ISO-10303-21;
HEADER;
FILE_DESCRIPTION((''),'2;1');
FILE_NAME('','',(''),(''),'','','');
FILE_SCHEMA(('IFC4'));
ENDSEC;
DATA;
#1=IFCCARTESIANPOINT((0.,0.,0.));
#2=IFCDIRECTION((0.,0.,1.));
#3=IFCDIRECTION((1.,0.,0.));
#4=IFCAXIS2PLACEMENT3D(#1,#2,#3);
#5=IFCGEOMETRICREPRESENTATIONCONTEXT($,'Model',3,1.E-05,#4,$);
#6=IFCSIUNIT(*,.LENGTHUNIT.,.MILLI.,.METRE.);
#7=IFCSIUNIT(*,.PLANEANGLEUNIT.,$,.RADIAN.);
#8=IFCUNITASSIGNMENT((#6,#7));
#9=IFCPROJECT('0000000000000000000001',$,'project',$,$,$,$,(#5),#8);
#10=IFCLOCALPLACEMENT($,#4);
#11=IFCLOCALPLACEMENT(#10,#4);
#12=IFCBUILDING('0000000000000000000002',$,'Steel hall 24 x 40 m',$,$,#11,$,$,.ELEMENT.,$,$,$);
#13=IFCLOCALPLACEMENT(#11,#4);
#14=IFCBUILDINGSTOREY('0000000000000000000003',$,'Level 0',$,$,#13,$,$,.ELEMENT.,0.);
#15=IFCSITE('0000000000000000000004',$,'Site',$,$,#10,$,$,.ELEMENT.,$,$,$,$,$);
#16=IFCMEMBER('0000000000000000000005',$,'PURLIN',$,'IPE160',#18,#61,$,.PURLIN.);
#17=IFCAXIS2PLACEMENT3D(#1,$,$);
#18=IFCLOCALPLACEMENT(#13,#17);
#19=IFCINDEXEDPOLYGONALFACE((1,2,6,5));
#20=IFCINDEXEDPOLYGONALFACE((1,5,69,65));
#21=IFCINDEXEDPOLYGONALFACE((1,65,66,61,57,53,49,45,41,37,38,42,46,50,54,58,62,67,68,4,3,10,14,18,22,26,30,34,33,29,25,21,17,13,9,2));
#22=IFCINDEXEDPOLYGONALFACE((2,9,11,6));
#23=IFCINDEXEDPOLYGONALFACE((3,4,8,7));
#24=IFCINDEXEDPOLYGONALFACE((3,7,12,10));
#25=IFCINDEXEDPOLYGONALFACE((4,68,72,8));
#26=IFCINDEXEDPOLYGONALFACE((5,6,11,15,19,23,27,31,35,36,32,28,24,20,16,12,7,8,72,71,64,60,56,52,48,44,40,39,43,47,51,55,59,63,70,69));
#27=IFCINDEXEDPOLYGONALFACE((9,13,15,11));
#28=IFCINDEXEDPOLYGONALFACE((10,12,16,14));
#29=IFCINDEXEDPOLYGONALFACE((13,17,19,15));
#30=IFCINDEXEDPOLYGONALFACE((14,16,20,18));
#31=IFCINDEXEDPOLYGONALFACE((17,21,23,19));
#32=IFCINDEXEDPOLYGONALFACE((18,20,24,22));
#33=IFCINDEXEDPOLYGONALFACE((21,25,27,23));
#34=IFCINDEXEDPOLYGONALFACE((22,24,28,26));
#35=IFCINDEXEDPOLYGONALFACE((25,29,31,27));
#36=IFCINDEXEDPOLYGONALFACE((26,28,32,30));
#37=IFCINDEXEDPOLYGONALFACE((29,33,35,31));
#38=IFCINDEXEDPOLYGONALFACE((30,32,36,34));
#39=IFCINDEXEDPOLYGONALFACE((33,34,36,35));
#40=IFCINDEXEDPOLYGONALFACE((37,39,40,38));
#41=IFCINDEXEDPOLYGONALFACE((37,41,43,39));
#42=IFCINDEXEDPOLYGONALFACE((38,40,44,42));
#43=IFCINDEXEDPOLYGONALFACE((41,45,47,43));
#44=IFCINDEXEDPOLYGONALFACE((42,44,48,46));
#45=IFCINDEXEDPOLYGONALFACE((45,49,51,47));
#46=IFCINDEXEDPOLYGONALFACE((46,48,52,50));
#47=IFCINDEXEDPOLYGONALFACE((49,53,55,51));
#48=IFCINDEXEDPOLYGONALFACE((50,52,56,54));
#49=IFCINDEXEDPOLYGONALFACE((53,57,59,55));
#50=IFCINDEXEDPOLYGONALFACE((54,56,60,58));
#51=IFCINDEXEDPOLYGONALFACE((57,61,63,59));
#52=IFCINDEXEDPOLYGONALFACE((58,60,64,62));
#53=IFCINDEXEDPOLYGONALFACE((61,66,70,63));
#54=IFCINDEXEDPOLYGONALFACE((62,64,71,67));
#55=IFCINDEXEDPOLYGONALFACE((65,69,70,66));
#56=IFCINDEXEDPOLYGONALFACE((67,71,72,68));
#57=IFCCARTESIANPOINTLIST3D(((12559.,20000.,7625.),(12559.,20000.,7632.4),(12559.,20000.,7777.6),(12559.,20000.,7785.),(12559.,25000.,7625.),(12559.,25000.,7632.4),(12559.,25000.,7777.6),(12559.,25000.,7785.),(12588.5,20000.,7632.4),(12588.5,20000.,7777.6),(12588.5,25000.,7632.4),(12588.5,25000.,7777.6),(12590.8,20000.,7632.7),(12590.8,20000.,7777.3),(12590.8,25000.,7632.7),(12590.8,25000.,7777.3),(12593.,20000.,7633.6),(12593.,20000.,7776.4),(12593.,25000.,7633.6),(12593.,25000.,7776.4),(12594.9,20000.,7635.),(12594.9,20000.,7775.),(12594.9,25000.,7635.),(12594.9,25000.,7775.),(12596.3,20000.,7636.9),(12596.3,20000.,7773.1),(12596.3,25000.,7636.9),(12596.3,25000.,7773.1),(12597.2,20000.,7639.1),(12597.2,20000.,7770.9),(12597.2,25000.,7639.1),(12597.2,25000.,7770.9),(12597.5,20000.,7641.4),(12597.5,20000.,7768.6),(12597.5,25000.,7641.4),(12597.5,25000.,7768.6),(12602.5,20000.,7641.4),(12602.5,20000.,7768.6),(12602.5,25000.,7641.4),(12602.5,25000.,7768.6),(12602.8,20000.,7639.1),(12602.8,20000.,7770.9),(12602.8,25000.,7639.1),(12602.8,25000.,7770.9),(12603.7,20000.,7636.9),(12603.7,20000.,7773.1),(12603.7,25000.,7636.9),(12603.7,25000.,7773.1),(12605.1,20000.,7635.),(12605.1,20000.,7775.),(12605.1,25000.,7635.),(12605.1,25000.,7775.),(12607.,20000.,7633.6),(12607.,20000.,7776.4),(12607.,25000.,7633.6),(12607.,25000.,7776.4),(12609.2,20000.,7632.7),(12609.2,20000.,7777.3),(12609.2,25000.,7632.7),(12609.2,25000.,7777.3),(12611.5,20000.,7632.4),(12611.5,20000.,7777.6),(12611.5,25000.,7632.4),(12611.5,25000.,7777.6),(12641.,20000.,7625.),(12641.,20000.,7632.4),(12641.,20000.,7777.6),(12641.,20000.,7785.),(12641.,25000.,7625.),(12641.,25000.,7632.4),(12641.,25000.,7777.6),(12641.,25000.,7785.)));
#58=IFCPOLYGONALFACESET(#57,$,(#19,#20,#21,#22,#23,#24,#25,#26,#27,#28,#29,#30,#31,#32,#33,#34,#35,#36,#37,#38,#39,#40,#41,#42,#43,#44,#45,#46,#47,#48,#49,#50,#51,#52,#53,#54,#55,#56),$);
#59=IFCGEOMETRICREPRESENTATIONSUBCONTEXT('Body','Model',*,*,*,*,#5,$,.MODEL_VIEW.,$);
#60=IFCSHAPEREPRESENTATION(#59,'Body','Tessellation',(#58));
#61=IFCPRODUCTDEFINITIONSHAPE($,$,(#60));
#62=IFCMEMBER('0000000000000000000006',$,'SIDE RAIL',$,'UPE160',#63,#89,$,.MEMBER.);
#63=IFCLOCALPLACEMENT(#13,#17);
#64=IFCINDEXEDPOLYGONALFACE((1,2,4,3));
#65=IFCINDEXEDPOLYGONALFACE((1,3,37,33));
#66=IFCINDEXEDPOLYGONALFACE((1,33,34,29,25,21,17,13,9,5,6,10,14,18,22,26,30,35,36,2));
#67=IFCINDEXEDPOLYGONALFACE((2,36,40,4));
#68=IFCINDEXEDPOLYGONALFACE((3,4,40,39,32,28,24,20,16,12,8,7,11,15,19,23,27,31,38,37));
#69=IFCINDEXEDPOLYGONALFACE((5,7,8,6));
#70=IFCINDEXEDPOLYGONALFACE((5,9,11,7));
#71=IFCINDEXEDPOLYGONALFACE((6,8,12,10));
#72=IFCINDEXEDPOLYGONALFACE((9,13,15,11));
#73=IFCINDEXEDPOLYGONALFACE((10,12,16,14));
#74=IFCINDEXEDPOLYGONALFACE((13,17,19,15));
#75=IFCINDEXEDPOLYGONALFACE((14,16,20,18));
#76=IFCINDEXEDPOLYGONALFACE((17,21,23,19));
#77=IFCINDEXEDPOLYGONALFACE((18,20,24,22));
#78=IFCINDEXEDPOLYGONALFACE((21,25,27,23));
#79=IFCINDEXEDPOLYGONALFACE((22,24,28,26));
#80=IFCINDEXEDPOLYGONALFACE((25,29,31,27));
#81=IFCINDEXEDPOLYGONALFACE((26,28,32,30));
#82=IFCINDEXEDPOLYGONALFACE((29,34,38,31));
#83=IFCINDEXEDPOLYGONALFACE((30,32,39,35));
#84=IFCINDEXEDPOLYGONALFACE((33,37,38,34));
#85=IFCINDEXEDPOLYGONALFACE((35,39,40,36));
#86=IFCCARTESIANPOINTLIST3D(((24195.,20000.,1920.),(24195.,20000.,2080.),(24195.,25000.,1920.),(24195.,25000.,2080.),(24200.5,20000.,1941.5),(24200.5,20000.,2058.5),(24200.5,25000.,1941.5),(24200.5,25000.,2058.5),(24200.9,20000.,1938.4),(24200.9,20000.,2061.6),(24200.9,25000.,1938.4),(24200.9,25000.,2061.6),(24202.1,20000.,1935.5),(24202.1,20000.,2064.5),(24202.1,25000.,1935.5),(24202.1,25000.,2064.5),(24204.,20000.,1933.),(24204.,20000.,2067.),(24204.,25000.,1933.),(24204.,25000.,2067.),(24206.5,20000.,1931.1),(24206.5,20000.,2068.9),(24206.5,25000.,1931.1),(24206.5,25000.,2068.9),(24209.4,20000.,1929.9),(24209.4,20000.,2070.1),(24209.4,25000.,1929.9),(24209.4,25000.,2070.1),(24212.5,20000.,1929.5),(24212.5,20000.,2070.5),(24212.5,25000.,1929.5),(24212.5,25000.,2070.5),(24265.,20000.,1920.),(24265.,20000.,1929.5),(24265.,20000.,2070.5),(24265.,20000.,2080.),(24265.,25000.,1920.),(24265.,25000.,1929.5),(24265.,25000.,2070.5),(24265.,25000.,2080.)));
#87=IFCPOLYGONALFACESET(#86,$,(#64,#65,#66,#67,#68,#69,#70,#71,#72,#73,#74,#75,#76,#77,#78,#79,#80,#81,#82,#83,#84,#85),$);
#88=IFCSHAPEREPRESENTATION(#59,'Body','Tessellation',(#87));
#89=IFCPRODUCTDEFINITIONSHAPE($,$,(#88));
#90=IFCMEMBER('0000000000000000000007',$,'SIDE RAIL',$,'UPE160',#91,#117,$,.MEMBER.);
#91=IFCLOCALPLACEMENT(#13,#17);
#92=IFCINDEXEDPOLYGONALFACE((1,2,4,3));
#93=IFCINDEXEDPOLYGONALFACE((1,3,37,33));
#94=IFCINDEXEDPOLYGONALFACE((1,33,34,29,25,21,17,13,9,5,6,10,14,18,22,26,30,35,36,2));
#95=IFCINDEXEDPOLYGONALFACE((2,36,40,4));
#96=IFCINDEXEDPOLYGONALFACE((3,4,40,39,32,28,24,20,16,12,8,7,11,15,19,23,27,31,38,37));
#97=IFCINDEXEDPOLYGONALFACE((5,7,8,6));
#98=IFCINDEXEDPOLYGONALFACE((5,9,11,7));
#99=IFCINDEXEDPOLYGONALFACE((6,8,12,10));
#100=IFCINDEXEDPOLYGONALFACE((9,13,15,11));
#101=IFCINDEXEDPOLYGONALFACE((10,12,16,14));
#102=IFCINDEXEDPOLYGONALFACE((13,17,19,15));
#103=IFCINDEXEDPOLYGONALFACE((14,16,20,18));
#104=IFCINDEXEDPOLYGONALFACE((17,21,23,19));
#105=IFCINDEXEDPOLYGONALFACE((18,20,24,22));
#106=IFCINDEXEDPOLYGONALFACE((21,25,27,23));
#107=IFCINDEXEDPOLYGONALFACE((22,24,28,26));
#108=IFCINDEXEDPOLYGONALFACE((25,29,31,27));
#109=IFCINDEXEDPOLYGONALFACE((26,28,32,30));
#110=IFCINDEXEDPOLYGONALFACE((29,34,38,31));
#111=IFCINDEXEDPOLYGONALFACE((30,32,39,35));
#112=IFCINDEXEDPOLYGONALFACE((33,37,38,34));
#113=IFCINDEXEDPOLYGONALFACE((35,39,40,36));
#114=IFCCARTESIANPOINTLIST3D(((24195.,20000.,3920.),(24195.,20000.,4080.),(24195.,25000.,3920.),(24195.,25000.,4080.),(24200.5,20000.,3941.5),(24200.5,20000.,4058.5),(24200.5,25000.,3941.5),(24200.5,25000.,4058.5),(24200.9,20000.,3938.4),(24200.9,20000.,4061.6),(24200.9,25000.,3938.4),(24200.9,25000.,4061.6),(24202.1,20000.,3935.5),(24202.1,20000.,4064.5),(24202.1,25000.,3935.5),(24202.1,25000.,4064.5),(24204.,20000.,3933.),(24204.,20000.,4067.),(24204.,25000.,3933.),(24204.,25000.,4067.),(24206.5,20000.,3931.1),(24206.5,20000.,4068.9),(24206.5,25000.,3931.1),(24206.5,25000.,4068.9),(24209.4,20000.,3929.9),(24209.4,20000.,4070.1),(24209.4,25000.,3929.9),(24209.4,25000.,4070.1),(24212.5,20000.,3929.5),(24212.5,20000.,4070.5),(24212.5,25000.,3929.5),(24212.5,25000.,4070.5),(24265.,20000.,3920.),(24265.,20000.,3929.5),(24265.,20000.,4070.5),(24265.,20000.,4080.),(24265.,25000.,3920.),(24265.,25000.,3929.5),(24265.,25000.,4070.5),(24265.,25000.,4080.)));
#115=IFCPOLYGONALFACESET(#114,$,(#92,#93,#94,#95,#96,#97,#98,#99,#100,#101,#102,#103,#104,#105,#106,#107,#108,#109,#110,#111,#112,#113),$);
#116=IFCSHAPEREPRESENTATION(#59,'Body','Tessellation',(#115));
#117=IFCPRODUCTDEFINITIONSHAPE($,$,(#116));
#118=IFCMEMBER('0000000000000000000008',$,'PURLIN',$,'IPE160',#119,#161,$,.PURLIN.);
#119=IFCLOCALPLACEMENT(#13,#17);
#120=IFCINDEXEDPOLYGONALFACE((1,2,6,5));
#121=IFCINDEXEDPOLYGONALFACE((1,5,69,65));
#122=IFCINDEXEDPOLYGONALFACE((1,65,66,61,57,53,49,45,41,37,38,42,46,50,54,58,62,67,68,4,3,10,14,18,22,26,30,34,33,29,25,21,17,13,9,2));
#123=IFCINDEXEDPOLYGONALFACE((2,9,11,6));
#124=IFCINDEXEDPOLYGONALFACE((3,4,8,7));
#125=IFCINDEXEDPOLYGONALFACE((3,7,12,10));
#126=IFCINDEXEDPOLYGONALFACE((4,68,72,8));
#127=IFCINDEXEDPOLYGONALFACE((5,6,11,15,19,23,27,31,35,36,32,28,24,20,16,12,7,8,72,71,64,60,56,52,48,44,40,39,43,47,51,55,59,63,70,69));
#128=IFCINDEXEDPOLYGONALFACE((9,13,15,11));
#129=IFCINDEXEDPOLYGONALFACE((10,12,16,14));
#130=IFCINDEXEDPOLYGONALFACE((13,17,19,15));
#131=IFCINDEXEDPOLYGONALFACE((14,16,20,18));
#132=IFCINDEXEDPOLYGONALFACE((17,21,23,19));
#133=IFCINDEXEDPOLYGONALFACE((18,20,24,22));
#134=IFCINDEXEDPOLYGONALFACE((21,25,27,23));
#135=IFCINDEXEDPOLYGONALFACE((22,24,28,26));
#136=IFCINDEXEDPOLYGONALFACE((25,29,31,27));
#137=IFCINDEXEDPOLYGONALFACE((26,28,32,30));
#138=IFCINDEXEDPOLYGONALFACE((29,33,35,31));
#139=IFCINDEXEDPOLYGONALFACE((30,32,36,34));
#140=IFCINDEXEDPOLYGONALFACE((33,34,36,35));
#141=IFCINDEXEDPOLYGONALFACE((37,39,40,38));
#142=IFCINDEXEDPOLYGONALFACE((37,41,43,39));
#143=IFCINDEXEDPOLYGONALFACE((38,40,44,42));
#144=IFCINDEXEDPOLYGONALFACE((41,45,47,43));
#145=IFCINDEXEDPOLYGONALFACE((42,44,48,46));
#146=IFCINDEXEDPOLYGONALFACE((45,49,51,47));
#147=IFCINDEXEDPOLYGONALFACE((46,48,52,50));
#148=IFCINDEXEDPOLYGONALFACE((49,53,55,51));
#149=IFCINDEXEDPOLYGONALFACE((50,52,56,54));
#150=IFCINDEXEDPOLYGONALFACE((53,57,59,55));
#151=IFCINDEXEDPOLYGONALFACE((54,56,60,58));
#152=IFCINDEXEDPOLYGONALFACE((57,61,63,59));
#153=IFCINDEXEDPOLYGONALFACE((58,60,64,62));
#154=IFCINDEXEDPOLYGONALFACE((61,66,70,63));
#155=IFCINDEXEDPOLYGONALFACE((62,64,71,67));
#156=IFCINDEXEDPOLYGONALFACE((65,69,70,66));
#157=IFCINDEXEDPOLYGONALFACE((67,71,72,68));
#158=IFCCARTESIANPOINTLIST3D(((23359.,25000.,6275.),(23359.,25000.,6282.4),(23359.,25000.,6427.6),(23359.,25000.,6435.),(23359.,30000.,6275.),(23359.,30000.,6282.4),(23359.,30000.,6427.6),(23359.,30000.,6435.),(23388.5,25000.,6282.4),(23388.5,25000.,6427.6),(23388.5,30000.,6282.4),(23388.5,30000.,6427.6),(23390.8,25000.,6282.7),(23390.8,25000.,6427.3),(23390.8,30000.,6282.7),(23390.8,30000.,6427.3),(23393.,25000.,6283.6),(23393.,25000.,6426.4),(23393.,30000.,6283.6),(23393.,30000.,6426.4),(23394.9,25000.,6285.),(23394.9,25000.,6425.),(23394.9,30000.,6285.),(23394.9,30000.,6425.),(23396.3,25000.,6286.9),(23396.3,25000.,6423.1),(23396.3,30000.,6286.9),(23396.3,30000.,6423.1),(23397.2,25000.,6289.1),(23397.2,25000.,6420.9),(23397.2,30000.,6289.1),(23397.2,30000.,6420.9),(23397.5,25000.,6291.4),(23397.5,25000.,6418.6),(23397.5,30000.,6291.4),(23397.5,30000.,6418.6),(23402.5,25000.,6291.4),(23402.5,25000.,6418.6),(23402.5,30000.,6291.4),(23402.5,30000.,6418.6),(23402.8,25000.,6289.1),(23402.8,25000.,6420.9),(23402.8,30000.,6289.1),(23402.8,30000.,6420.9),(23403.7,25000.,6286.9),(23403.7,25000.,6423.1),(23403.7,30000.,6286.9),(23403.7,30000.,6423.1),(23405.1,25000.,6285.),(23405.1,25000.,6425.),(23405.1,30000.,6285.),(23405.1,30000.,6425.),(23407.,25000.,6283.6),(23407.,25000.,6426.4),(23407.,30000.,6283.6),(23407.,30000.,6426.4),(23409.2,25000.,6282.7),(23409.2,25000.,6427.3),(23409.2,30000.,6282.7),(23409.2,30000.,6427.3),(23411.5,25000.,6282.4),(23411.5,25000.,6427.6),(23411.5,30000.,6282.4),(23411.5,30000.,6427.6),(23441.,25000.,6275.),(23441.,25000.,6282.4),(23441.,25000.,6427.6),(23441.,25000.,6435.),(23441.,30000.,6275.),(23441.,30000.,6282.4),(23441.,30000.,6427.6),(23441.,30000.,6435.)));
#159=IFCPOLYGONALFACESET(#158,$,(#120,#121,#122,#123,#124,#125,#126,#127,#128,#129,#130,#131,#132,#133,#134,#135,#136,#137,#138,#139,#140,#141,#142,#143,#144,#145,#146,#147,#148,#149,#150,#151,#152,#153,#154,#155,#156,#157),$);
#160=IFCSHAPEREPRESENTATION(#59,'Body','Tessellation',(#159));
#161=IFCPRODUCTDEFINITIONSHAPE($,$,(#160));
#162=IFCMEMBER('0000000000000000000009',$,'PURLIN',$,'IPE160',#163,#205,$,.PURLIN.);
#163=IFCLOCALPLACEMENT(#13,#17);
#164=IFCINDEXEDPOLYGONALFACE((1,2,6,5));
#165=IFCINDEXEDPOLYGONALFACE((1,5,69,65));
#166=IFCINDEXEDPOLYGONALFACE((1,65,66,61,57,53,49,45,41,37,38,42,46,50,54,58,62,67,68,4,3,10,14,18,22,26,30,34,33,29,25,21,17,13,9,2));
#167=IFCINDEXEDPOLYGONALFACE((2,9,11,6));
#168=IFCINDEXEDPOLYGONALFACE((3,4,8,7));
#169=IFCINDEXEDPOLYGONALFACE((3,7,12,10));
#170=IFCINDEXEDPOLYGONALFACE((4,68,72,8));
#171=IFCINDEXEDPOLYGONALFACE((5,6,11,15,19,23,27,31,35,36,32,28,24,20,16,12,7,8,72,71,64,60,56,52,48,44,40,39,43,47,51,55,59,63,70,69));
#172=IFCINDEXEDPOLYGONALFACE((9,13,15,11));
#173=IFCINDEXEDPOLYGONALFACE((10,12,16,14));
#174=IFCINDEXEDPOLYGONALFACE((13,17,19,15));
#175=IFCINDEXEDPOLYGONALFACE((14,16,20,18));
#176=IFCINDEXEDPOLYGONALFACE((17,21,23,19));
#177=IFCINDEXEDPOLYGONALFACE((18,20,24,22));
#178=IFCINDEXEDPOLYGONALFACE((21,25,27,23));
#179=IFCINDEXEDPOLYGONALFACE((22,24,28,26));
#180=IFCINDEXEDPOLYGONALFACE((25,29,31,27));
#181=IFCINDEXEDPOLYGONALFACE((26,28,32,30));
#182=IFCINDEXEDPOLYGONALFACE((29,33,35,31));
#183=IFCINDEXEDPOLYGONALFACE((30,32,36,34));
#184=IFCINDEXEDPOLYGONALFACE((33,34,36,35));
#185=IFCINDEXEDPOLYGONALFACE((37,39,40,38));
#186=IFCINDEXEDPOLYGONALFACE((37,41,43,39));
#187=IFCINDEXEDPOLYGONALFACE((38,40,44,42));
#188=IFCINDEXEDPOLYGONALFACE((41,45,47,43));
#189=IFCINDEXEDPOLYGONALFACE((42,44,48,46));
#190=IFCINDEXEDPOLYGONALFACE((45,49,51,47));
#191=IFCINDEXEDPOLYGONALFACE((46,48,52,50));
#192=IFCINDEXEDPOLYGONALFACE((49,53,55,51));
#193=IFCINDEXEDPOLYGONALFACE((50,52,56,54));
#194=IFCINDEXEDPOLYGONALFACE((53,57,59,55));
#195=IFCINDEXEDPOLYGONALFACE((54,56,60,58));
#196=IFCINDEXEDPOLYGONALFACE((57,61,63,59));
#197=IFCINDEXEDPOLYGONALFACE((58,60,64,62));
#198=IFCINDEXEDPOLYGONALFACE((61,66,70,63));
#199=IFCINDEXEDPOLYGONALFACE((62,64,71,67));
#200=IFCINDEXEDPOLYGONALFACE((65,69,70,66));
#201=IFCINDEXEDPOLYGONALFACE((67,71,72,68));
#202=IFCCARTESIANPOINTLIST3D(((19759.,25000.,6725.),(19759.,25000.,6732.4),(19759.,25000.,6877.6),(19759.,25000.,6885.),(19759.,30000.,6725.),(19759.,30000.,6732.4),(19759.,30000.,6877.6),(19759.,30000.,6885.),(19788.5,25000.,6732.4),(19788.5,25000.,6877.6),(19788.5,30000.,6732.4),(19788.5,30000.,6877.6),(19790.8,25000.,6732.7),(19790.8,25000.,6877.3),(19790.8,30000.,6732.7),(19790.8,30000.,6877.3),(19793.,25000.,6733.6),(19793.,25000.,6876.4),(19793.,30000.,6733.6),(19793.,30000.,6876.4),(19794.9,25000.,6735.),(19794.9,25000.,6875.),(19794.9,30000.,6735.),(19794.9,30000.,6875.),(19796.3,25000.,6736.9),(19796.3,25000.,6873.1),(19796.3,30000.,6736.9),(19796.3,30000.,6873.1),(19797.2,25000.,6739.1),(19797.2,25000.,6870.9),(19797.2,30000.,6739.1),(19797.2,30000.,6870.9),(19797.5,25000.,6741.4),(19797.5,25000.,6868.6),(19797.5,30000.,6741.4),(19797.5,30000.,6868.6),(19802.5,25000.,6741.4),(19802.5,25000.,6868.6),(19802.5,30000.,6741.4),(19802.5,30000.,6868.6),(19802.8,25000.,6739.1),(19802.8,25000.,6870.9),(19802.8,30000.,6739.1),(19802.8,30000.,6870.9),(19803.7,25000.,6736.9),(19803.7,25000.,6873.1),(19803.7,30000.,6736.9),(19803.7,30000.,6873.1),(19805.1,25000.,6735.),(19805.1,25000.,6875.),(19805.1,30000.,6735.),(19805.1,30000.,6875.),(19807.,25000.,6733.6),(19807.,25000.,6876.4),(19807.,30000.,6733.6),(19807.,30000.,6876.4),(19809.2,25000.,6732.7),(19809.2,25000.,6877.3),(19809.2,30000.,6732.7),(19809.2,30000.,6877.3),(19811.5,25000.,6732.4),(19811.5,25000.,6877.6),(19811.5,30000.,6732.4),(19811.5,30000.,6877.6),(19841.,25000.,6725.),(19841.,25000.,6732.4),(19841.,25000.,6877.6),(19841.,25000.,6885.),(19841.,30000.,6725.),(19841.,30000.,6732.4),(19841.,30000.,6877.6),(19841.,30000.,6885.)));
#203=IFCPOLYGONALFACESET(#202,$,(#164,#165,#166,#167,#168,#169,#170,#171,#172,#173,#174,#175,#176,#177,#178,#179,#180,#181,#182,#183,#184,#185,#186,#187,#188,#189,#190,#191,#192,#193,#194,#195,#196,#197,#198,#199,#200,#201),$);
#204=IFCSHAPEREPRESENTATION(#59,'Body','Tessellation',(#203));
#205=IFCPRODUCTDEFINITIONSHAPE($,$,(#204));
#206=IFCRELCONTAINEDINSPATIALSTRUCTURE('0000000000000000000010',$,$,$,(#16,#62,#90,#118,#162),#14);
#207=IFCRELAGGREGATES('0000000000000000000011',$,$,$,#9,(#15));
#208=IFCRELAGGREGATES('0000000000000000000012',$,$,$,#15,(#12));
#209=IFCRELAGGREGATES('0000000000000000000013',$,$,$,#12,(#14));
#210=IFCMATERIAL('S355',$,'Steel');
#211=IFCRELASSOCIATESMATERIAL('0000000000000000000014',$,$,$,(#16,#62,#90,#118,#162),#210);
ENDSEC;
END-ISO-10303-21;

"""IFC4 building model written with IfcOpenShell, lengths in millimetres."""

from ifc_helpers import new_model, si_unit, frame, origin_with_axes, place, context, subcontext, project, spatial, i_section, u_section, extrude, material, element, save


model = new_model("IFC4")

# Units and contexts
model_context = context("Model", 3, precision=1e-05, world=origin_with_axes())
body_context = subcontext(model_context, "Body", "Model", "MODEL_VIEW")
ifc_project = project(units=[si_unit("LENGTHUNIT", "METRE", prefix="MILLI"), si_unit("PLANEANGLEUNIT", "RADIAN")], contexts=[model_context])

# Site, building, storey
site_placement = place(None, origin_with_axes())
site = spatial("IfcSite", under=ifc_project, at=site_placement, Name="Site", CompositionType="ELEMENT")
building_placement = place(site_placement, origin_with_axes())
building = spatial("IfcBuilding", under=site, at=building_placement, Name="Steel hall 24 x 40 m", CompositionType="ELEMENT")
storey_placement = place(building_placement, origin_with_axes())
storey = spatial("IfcBuildingStorey", under=building, at=storey_placement, Name="Level 0", CompositionType="ELEMENT", Elevation=0.0)

# Shared definitions
ifc_material = material(Name="S355", Category="Steel")

# Members
for number, where, z_axis, x_axis, name in (
    (1, (12600.0, 20000.0, 7705.0), (0.0, 1.0, 0.0), (1.0, 0.0, 0.0), "PURLIN"),
):
    element("IfcMember", number, at=place(storey_placement, frame(where, z_axis=z_axis, x_axis=x_axis)), inside=storey, material=ifc_material, Name=name, ObjectType="IPE160", PredefinedType="PURLIN", context=body_context, shape_type="SweptSolid", body=[
        extrude(i_section(OverallWidth=82.0, OverallDepth=160.0, WebThickness=5.0, FlangeThickness=7.4, FilletRadius=9.0), origin_with_axes(), (0.0, 0.0, 1.0), 5000.0),
    ])
for number, where, z_axis, x_axis, name in (
    (2, (24230.0, 20000.0, 2000.0), (0.0, 1.0, 0.0), (1.0, 0.0, 0.0), "SIDE RAIL"),
    (3, (24230.0, 20000.0, 4000.0), (0.0, 1.0, 0.0), (1.0, 0.0, 0.0), "SIDE RAIL"),
):
    element("IfcMember", number, at=place(storey_placement, frame(where, z_axis=z_axis, x_axis=x_axis)), inside=storey, material=ifc_material, Name=name, ObjectType="UPE160", PredefinedType="MEMBER", context=body_context, shape_type="SweptSolid", body=[
        extrude(u_section(Depth=160.0, FlangeWidth=70.0, WebThickness=5.5, FlangeThickness=9.5, FilletRadius=12.0), origin_with_axes(), (0.0, 0.0, 1.0), 5000.0),
    ])
for number, where, z_axis, x_axis, name in (
    (4, (23400.0, 25000.0, 6355.0), (0.0, 1.0, 0.0), (1.0, 0.0, 0.0), "PURLIN"),
    (5, (19800.0, 25000.0, 6805.0), (0.0, 1.0, 0.0), (1.0, 0.0, 0.0), "PURLIN"),
):
    element("IfcMember", number, at=place(storey_placement, frame(where, z_axis=z_axis, x_axis=x_axis)), inside=storey, material=ifc_material, Name=name, ObjectType="IPE160", PredefinedType="PURLIN", context=body_context, shape_type="SweptSolid", body=[
        extrude(i_section(OverallWidth=82.0, OverallDepth=160.0, WebThickness=5.0, FlangeThickness=7.4, FilletRadius=9.0), origin_with_axes(), (0.0, 0.0, 1.0), 5000.0),
    ])

save(model, "model.ifc")
